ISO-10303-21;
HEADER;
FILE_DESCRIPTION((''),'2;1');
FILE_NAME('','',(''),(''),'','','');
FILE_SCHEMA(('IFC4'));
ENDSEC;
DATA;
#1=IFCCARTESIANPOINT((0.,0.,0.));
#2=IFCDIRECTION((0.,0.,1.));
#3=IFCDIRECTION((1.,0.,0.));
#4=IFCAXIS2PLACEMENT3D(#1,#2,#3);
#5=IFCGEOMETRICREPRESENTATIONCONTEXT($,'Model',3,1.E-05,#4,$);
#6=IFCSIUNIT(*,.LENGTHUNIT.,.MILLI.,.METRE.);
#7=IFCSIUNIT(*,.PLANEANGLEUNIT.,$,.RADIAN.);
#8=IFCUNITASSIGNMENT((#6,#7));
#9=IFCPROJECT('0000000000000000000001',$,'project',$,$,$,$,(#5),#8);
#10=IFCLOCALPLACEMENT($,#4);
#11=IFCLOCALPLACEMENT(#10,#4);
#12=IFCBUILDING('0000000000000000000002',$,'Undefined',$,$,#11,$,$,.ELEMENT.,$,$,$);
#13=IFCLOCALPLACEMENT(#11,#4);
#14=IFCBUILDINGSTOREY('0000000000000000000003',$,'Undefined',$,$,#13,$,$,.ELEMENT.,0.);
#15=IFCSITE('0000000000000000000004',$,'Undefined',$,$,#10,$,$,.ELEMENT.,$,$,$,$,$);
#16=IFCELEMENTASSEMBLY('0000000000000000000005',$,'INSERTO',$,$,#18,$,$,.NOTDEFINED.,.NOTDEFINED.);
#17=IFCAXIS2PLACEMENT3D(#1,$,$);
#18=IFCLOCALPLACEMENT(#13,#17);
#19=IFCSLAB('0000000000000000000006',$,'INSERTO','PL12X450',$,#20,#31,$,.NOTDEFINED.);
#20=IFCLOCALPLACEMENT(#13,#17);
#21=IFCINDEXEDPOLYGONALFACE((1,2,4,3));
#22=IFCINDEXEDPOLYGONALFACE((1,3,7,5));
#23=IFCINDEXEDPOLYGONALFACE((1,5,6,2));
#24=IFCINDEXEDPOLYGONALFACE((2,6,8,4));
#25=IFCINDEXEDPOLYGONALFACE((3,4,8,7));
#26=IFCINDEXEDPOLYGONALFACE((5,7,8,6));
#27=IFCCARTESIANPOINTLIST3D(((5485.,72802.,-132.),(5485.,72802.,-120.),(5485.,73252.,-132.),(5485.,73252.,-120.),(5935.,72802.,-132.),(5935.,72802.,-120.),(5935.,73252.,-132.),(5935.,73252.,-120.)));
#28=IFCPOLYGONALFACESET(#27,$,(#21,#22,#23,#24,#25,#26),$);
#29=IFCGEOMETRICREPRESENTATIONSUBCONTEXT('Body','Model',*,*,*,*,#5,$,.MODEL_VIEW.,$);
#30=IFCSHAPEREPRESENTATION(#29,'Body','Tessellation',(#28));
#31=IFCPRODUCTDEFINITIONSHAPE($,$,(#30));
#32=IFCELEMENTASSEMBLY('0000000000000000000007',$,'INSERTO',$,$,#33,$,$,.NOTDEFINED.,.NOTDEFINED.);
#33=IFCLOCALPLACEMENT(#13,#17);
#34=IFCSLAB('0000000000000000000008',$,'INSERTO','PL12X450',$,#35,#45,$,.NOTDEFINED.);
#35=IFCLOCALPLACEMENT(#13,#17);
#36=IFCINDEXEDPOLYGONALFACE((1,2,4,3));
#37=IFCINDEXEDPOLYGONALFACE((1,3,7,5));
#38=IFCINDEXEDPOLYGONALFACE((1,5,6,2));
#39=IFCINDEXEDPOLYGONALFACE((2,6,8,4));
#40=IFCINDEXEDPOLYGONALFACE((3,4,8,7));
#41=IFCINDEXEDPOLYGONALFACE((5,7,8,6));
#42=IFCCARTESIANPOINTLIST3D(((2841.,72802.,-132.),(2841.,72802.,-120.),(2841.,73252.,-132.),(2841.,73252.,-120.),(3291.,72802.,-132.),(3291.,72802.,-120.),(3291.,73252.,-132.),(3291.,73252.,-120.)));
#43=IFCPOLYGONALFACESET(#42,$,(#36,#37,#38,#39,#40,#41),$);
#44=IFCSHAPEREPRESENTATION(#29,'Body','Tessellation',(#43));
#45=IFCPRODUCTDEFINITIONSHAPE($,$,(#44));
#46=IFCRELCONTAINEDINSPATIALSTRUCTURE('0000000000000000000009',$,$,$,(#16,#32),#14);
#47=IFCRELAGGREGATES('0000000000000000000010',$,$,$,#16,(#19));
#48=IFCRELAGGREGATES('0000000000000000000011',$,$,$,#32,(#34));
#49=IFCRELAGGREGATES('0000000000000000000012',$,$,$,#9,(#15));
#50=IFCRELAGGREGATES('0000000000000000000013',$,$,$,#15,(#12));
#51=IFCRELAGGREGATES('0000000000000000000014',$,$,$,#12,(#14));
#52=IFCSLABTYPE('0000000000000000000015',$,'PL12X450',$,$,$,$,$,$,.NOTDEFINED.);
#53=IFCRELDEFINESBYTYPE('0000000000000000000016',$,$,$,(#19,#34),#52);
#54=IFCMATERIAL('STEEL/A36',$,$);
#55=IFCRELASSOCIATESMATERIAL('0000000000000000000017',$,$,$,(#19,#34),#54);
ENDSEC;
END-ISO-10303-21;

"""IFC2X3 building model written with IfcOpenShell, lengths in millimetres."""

from ifc_helpers import new_model, si_unit, frame, origin_with_axes, place, context, subcontext, project, spatial, polyline, outline, extrude, material, type_object, element, aggregate, save


model = new_model("IFC2X3")

# Units and contexts
model_context = context("Model", 3, precision=1e-05, world=origin_with_axes())
body_context = subcontext(model_context, "Body", "Model", "MODEL_VIEW")
ifc_project = project(units=[si_unit("LENGTHUNIT", "METRE", prefix="MILLI"), si_unit("PLANEANGLEUNIT", "RADIAN")], contexts=[model_context])

# Site, building, storey
site_placement = place(None, origin_with_axes())
site = spatial("IfcSite", under=ifc_project, at=site_placement, Name="Undefined", CompositionType="ELEMENT")
building_placement = place(site_placement, origin_with_axes())
building = spatial("IfcBuilding", under=site, at=building_placement, Name="Undefined", CompositionType="ELEMENT")
storey_placement = place(building_placement, origin_with_axes())
storey = spatial("IfcBuildingStorey", under=building, at=storey_placement, Name="Undefined", CompositionType="ELEMENT", Elevation=0.0)

# Shared definitions
ifc_material_1 = material(Name="STEEL/A36")

# Element assemblies, slabs
assembly_1_placement = place(storey_placement, origin_with_axes())
assembly_1 = element("IfcElementAssembly", 1, at=assembly_1_placement, inside=storey, Name="INSERTO", AssemblyPlace="NOTDEFINED", PredefinedType="NOTDEFINED")
slab_type_1 = type_object("IfcSlabType", Name="PL12X450", PredefinedType="NOTDEFINED")
slab_1_placement = place(assembly_1_placement, frame((5485.0, 72802.0, -126.0), z_axis=(0.0, 0.0, 1.0), x_axis=(1.0, 0.0, 0.0)))
slab_1 = element("IfcSlab", 2, at=slab_1_placement, type_object=slab_type_1, material=ifc_material_1, Name="INSERTO", Description="PL12X450", PredefinedType="NOTDEFINED", context=body_context, shape_type="SweptSolid", body=[
    extrude(outline(polyline([(0.0, 0.0), (450.0, 0.0), (450.0, 450.0), (0.0, 450.0), (0.0, 0.0)])), frame((0.0, 0.0, -6.0), z_axis=(0.0, 0.0, 1.0), x_axis=(1.0, 0.0, 0.0)), (0.0, 0.0, 1.0), 12.0),
])
assembly_2_placement = place(storey_placement, origin_with_axes())
assembly_2 = element("IfcElementAssembly", 3, at=assembly_2_placement, inside=storey, Name="INSERTO", AssemblyPlace="NOTDEFINED", PredefinedType="NOTDEFINED")
slab_2_placement = place(assembly_2_placement, frame((2841.0, 72802.0, -126.0), z_axis=(0.0, 0.0, 1.0), x_axis=(1.0, 0.0, 0.0)))
slab_2 = element("IfcSlab", 4, at=slab_2_placement, type_object=slab_type_1, material=ifc_material_1, Name="INSERTO", Description="PL12X450", PredefinedType="NOTDEFINED", context=body_context, shape_type="SweptSolid", body=[
    extrude(outline(polyline([(0.0, 0.0), (450.0, 0.0), (450.0, 450.0), (0.0, 450.0), (0.0, 0.0)])), frame((0.0, 0.0, -6.0), z_axis=(0.0, 0.0, 1.0), x_axis=(1.0, 0.0, 0.0)), (0.0, 0.0, 1.0), 12.0),
])

aggregate(assembly_1, [slab_1])
aggregate(assembly_2, [slab_2])

save(model, "model.ifc")
